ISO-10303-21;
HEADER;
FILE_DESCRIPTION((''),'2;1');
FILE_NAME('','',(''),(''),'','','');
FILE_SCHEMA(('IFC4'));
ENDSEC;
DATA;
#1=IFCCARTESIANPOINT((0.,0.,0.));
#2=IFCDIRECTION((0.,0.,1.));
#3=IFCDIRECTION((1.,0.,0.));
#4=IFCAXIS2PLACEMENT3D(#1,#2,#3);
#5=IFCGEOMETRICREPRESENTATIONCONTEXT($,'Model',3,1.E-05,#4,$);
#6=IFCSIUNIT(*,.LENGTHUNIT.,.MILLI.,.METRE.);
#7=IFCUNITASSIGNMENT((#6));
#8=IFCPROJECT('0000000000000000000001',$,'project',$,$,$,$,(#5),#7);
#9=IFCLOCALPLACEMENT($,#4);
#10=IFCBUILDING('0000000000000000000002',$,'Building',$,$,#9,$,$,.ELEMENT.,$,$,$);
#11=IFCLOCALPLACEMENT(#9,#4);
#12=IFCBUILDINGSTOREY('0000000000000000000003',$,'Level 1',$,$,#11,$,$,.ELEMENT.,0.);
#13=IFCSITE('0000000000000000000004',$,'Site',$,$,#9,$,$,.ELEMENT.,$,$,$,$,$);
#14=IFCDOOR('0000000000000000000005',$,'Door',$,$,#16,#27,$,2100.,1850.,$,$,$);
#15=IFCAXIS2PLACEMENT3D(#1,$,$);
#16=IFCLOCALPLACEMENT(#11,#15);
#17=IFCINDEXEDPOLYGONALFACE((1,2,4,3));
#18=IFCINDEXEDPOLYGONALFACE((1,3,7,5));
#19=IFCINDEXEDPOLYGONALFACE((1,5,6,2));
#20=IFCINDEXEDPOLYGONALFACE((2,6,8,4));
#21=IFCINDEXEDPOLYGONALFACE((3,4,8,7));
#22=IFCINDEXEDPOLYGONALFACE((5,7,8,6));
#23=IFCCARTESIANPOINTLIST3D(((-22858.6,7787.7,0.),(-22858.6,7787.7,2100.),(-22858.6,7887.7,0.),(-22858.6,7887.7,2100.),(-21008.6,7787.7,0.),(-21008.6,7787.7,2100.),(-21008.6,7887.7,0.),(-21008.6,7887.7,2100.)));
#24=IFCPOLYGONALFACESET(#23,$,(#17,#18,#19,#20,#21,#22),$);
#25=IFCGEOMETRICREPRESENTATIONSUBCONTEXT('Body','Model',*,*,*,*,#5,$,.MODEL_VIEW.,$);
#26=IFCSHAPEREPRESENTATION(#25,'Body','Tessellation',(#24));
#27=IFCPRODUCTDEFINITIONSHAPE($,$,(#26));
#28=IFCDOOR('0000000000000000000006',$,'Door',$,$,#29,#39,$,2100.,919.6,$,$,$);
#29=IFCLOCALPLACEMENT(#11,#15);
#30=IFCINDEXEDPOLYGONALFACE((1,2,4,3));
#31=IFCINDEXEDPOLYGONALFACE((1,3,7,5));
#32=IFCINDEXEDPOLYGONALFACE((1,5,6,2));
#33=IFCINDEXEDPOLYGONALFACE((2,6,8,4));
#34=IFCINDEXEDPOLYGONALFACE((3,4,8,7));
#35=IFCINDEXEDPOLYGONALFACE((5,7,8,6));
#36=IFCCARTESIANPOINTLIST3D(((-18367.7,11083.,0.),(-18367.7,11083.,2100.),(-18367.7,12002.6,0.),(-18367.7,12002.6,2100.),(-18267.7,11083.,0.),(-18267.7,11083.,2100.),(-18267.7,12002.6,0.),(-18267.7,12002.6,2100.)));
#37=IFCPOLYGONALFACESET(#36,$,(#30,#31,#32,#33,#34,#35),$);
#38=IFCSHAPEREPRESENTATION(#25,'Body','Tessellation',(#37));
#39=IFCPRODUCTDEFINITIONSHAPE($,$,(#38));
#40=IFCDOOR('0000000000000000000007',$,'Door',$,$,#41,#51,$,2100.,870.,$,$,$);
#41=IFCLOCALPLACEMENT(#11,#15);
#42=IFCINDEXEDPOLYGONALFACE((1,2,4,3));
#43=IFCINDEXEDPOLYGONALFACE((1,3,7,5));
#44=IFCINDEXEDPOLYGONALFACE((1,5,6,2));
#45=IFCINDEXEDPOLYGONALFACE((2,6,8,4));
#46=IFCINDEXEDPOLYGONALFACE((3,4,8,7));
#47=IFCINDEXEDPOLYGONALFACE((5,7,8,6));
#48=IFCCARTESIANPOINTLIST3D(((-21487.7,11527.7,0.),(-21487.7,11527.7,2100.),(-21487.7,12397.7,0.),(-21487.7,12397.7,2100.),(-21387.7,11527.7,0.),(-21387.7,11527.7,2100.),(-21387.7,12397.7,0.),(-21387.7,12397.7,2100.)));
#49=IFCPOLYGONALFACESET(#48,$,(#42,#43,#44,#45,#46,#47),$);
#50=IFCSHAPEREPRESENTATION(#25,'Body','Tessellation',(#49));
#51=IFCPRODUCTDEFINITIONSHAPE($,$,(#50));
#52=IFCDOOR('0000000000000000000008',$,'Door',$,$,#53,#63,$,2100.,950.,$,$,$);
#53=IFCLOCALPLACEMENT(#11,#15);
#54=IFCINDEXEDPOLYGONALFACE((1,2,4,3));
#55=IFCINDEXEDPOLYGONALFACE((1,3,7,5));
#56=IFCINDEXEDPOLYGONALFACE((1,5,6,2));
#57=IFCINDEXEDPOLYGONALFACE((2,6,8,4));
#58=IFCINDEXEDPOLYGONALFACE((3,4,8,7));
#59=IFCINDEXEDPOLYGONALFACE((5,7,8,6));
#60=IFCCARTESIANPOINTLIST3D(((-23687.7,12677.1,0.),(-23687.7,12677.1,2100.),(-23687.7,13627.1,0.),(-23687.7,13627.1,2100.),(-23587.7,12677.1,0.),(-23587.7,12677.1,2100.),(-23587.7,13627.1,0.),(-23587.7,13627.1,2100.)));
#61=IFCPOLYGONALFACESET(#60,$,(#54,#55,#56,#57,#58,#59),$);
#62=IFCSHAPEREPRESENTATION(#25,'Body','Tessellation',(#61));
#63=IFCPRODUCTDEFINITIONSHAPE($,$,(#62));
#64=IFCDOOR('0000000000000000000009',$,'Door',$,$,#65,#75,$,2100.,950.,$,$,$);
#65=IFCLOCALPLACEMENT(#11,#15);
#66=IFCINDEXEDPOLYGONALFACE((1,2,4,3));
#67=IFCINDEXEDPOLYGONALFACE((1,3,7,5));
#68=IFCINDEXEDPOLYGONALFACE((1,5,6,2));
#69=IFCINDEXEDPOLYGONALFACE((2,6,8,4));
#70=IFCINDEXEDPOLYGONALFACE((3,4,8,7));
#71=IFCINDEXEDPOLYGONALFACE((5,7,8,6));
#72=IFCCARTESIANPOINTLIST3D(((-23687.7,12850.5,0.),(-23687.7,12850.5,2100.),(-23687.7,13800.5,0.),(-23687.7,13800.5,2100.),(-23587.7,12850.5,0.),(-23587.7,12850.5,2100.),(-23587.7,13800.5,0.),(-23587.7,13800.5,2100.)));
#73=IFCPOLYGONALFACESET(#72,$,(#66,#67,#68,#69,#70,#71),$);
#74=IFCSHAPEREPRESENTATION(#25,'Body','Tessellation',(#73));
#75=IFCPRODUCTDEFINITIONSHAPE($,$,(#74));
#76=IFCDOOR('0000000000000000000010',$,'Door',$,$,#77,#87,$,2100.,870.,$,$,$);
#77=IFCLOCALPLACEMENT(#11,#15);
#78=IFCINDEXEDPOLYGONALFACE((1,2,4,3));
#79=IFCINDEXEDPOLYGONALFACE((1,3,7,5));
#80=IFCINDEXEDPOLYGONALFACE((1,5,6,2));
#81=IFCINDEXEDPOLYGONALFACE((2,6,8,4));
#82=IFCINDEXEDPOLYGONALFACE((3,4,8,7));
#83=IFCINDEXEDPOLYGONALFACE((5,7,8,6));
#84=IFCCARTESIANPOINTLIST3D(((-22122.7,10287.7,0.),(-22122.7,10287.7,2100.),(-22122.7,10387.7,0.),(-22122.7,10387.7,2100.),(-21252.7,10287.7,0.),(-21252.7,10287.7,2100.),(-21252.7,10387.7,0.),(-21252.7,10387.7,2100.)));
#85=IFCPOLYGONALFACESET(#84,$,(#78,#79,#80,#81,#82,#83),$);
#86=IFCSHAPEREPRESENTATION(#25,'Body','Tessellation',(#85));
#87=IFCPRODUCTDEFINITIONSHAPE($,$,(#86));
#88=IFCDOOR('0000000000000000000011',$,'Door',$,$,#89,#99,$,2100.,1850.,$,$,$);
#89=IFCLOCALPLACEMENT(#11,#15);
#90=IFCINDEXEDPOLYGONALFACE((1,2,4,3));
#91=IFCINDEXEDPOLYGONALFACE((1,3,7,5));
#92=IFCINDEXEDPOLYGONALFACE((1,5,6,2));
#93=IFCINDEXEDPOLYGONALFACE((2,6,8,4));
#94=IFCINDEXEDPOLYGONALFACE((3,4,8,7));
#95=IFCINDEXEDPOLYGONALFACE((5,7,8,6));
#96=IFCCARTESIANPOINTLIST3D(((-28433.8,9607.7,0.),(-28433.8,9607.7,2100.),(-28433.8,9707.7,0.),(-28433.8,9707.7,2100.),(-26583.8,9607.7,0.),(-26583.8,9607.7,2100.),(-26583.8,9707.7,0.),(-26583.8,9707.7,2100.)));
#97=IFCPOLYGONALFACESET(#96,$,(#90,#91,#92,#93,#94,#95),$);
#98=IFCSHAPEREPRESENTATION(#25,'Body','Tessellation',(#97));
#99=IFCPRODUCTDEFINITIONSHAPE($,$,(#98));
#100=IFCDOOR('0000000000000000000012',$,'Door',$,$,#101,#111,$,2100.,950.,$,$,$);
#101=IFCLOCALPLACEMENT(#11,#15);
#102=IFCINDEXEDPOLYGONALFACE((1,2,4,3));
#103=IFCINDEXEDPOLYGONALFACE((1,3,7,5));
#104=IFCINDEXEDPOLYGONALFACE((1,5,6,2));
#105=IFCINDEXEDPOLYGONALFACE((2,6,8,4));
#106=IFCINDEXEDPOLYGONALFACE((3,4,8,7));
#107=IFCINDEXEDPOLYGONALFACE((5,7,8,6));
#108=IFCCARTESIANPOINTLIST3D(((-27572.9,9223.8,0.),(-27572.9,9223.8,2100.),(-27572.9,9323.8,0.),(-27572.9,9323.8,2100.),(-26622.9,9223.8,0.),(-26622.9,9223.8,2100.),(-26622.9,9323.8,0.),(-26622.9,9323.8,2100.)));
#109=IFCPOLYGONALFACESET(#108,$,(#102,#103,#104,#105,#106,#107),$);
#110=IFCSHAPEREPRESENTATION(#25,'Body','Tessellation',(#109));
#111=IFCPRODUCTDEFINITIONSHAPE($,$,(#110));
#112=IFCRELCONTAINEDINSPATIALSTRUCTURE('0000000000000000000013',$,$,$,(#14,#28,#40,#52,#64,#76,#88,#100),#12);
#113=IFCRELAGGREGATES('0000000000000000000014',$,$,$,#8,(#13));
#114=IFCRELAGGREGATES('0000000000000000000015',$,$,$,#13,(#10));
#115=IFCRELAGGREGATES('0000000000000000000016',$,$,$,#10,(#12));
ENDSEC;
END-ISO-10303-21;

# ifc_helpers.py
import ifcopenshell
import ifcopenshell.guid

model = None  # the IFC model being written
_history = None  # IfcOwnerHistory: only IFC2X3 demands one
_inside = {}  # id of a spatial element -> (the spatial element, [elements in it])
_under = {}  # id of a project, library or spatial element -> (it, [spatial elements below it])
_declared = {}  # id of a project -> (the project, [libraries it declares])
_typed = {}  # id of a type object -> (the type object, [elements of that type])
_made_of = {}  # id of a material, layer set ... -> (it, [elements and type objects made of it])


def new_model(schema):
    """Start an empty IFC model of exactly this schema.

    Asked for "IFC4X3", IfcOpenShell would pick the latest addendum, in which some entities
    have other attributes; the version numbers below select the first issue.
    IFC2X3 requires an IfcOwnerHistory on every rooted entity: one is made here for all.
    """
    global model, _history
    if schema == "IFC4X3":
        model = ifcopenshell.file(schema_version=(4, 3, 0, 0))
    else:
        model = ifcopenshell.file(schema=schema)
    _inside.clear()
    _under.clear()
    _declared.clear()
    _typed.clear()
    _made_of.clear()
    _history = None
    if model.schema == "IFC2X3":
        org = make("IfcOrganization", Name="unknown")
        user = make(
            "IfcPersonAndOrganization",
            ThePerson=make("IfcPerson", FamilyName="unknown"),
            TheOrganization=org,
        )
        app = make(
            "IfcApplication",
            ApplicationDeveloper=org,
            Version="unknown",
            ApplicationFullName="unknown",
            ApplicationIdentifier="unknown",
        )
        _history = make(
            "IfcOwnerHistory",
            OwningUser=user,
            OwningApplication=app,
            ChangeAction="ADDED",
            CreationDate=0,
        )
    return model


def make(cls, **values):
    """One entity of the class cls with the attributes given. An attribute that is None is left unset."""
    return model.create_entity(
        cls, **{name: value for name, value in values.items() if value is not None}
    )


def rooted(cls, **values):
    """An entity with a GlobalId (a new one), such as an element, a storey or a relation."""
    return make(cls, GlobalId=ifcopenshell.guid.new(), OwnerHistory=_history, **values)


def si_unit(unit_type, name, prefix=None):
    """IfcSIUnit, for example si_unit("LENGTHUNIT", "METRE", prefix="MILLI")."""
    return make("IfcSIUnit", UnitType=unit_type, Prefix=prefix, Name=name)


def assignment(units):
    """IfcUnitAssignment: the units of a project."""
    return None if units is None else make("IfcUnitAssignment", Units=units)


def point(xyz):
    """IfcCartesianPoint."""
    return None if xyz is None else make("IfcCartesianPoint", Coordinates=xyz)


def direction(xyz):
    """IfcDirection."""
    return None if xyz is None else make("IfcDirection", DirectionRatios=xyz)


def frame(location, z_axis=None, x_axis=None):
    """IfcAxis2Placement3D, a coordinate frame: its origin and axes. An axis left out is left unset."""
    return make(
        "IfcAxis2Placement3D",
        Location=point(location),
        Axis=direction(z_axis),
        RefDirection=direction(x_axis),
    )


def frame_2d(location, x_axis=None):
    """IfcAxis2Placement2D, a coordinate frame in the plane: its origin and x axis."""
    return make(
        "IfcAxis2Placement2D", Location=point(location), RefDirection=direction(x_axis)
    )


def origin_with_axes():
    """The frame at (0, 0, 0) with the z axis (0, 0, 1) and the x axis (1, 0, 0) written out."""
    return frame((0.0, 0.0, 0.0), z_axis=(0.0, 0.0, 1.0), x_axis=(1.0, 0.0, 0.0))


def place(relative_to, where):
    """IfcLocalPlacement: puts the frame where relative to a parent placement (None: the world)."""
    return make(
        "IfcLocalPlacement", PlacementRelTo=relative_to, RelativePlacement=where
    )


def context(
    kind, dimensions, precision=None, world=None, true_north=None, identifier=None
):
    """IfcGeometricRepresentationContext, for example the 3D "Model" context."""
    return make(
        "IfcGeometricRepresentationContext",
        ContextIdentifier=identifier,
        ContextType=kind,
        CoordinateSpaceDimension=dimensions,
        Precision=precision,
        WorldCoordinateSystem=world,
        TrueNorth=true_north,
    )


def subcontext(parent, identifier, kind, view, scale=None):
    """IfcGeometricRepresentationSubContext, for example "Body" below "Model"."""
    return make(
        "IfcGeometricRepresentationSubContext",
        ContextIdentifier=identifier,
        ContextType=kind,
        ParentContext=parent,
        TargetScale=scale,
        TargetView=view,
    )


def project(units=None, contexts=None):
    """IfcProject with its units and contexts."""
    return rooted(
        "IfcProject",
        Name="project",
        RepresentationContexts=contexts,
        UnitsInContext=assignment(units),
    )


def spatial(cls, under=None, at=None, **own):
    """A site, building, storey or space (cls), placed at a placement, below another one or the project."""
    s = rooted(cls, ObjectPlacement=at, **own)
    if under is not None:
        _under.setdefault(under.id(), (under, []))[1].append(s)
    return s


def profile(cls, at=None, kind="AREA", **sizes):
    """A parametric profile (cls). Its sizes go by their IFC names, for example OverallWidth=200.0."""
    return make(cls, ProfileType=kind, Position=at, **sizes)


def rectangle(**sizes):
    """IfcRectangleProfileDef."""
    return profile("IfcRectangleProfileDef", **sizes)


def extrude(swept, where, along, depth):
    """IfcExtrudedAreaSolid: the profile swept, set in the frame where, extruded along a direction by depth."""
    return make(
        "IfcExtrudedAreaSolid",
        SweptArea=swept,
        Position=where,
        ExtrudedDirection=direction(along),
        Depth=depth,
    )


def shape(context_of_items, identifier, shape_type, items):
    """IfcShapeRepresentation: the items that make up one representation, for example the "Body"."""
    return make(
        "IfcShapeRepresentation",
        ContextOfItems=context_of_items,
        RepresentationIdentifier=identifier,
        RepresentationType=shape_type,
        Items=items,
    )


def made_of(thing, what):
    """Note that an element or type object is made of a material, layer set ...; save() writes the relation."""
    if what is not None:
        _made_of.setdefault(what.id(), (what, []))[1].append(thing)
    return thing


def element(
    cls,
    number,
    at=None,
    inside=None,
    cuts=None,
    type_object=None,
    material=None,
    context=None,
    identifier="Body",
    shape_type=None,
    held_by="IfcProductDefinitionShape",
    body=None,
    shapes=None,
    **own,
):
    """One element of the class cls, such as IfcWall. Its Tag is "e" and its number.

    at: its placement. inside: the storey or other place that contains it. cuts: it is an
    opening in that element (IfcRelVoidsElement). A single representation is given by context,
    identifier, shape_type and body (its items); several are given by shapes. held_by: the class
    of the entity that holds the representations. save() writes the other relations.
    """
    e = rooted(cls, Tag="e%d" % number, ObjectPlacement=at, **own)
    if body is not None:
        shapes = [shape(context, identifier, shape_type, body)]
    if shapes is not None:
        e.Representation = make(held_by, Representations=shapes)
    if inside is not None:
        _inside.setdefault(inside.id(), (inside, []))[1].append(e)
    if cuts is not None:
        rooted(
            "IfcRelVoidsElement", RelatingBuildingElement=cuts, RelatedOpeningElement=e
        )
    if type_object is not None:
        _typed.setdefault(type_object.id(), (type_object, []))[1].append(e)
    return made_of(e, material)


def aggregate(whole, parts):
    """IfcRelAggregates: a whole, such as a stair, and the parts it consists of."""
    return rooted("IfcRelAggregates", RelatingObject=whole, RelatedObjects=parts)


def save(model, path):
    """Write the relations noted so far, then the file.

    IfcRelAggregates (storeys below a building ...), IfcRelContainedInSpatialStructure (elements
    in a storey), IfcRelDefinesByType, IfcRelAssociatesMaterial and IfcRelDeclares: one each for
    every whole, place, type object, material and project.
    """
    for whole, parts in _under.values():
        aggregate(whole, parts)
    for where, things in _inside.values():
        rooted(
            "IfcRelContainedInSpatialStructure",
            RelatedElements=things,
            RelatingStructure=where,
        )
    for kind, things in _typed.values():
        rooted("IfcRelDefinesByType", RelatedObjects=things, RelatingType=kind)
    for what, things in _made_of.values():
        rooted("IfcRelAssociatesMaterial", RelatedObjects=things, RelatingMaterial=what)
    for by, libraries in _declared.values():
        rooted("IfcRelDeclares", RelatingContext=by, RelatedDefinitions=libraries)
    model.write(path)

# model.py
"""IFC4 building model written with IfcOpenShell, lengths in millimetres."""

from ifc_helpers import new_model, si_unit, frame, frame_2d, origin_with_axes, place, context, subcontext, project, spatial, rectangle, extrude, element, save


model = new_model("IFC4")

# Units and contexts
model_context = context("Model", 3, precision=1e-05, world=origin_with_axes())
body_context = subcontext(model_context, "Body", "Model", "MODEL_VIEW")
ifc_project = project(units=[si_unit("LENGTHUNIT", "METRE", prefix="MILLI")], contexts=[model_context])

# Site, building, storey
placement = place(None, origin_with_axes())
site = spatial("IfcSite", under=ifc_project, at=placement, Name="Site", CompositionType="ELEMENT")
building = spatial("IfcBuilding", under=site, at=placement, Name="Building", CompositionType="ELEMENT")
storey_placement = place(placement, origin_with_axes())
storey = spatial("IfcBuildingStorey", under=building, at=storey_placement, Name="Level 1", CompositionType="ELEMENT", Elevation=0.0)

# Doors
door_1_placement = place(placement, frame((-22858.6, 7837.7, 0.0), z_axis=(0.0, 0.0, 1.0), x_axis=(1.0, 0.0, 0.0)))
element("IfcDoor", 1, at=door_1_placement, inside=storey, Name="Door", OverallHeight=2100.0, OverallWidth=1850.0, context=body_context, shape_type="SweptSolid", body=[
    extrude(rectangle(XDim=1850.0, YDim=100.0, at=frame_2d((925.0, 0.0), x_axis=(1.0, 0.0))), origin_with_axes(), (0.0, 0.0, 1.0), 2100.0),
])
door_2_placement = place(placement, frame((-18317.7, 11083.0, 0.0), z_axis=(0.0, 0.0, 1.0), x_axis=(0.0, 1.0, 0.0)))
element("IfcDoor", 2, at=door_2_placement, inside=storey, Name="Door", OverallHeight=2100.0, OverallWidth=919.6, context=body_context, shape_type="SweptSolid", body=[
    extrude(rectangle(XDim=919.6, YDim=100.0, at=frame_2d((459.8, 0.0), x_axis=(1.0, 0.0))), origin_with_axes(), (0.0, 0.0, 1.0), 2100.0),
])
door_3_placement = place(placement, frame((-21437.7, 11527.7, 0.0), z_axis=(0.0, 0.0, 1.0), x_axis=(0.0, 1.0, 0.0)))
element("IfcDoor", 3, at=door_3_placement, inside=storey, Name="Door", OverallHeight=2100.0, OverallWidth=870.0, context=body_context, shape_type="SweptSolid", body=[
    extrude(rectangle(XDim=870.0, YDim=100.0, at=frame_2d((435.0, 0.0), x_axis=(1.0, 0.0))), origin_with_axes(), (0.0, 0.0, 1.0), 2100.0),
])
for number, where, z_axis, x_axis, name in (
    (4, (-23637.7, 13627.1, 0.0), (0.0, 0.0, 1.0), (0.0, -1.0, 0.0), "Door"),
    (5, (-23637.7, 13800.5, 0.0), (0.0, 0.0, 1.0), (0.0, -1.0, 0.0), "Door"),
):
    element("IfcDoor", number, at=place(placement, frame(where, z_axis=z_axis, x_axis=x_axis)), inside=storey, Name=name, OverallHeight=2100.0, OverallWidth=950.0, context=body_context, shape_type="SweptSolid", body=[
        extrude(rectangle(XDim=950.0, YDim=100.0, at=frame_2d((475.0, 0.0), x_axis=(1.0, 0.0))), origin_with_axes(), (0.0, 0.0, 1.0), 2100.0),
    ])
door_4_placement = place(placement, frame((-22122.7, 10337.7, 0.0), z_axis=(0.0, 0.0, 1.0), x_axis=(1.0, 0.0, 0.0)))
element("IfcDoor", 6, at=door_4_placement, inside=storey, Name="Door", OverallHeight=2100.0, OverallWidth=870.0, context=body_context, shape_type="SweptSolid", body=[
    extrude(rectangle(XDim=870.0, YDim=100.0, at=frame_2d((435.0, 0.0), x_axis=(1.0, 0.0))), origin_with_axes(), (0.0, 0.0, 1.0), 2100.0),
])
door_5_placement = place(placement, frame((-26583.8, 9657.7, 0.0), z_axis=(0.0, 0.0, 1.0), x_axis=(-1.0, 0.0, 0.0)))
element("IfcDoor", 7, at=door_5_placement, inside=storey, Name="Door", OverallHeight=2100.0, OverallWidth=1850.0, context=body_context, shape_type="SweptSolid", body=[
    extrude(rectangle(XDim=1850.0, YDim=100.0, at=frame_2d((925.0, 0.0), x_axis=(1.0, 0.0))), origin_with_axes(), (0.0, 0.0, 1.0), 2100.0),
])
door_6_placement = place(placement, frame((-26622.9, 9273.8, 0.0), z_axis=(0.0, 0.0, 1.0), x_axis=(-1.0, 0.0, 0.0)))
element("IfcDoor", 8, at=door_6_placement, inside=storey, Name="Door", OverallHeight=2100.0, OverallWidth=950.0, context=body_context, shape_type="SweptSolid", body=[
    extrude(rectangle(XDim=950.0, YDim=100.0, at=frame_2d((475.0, 0.0), x_axis=(1.0, 0.0))), origin_with_axes(), (0.0, 0.0, 1.0), 2100.0),
])

save(model, "model.ifc")
